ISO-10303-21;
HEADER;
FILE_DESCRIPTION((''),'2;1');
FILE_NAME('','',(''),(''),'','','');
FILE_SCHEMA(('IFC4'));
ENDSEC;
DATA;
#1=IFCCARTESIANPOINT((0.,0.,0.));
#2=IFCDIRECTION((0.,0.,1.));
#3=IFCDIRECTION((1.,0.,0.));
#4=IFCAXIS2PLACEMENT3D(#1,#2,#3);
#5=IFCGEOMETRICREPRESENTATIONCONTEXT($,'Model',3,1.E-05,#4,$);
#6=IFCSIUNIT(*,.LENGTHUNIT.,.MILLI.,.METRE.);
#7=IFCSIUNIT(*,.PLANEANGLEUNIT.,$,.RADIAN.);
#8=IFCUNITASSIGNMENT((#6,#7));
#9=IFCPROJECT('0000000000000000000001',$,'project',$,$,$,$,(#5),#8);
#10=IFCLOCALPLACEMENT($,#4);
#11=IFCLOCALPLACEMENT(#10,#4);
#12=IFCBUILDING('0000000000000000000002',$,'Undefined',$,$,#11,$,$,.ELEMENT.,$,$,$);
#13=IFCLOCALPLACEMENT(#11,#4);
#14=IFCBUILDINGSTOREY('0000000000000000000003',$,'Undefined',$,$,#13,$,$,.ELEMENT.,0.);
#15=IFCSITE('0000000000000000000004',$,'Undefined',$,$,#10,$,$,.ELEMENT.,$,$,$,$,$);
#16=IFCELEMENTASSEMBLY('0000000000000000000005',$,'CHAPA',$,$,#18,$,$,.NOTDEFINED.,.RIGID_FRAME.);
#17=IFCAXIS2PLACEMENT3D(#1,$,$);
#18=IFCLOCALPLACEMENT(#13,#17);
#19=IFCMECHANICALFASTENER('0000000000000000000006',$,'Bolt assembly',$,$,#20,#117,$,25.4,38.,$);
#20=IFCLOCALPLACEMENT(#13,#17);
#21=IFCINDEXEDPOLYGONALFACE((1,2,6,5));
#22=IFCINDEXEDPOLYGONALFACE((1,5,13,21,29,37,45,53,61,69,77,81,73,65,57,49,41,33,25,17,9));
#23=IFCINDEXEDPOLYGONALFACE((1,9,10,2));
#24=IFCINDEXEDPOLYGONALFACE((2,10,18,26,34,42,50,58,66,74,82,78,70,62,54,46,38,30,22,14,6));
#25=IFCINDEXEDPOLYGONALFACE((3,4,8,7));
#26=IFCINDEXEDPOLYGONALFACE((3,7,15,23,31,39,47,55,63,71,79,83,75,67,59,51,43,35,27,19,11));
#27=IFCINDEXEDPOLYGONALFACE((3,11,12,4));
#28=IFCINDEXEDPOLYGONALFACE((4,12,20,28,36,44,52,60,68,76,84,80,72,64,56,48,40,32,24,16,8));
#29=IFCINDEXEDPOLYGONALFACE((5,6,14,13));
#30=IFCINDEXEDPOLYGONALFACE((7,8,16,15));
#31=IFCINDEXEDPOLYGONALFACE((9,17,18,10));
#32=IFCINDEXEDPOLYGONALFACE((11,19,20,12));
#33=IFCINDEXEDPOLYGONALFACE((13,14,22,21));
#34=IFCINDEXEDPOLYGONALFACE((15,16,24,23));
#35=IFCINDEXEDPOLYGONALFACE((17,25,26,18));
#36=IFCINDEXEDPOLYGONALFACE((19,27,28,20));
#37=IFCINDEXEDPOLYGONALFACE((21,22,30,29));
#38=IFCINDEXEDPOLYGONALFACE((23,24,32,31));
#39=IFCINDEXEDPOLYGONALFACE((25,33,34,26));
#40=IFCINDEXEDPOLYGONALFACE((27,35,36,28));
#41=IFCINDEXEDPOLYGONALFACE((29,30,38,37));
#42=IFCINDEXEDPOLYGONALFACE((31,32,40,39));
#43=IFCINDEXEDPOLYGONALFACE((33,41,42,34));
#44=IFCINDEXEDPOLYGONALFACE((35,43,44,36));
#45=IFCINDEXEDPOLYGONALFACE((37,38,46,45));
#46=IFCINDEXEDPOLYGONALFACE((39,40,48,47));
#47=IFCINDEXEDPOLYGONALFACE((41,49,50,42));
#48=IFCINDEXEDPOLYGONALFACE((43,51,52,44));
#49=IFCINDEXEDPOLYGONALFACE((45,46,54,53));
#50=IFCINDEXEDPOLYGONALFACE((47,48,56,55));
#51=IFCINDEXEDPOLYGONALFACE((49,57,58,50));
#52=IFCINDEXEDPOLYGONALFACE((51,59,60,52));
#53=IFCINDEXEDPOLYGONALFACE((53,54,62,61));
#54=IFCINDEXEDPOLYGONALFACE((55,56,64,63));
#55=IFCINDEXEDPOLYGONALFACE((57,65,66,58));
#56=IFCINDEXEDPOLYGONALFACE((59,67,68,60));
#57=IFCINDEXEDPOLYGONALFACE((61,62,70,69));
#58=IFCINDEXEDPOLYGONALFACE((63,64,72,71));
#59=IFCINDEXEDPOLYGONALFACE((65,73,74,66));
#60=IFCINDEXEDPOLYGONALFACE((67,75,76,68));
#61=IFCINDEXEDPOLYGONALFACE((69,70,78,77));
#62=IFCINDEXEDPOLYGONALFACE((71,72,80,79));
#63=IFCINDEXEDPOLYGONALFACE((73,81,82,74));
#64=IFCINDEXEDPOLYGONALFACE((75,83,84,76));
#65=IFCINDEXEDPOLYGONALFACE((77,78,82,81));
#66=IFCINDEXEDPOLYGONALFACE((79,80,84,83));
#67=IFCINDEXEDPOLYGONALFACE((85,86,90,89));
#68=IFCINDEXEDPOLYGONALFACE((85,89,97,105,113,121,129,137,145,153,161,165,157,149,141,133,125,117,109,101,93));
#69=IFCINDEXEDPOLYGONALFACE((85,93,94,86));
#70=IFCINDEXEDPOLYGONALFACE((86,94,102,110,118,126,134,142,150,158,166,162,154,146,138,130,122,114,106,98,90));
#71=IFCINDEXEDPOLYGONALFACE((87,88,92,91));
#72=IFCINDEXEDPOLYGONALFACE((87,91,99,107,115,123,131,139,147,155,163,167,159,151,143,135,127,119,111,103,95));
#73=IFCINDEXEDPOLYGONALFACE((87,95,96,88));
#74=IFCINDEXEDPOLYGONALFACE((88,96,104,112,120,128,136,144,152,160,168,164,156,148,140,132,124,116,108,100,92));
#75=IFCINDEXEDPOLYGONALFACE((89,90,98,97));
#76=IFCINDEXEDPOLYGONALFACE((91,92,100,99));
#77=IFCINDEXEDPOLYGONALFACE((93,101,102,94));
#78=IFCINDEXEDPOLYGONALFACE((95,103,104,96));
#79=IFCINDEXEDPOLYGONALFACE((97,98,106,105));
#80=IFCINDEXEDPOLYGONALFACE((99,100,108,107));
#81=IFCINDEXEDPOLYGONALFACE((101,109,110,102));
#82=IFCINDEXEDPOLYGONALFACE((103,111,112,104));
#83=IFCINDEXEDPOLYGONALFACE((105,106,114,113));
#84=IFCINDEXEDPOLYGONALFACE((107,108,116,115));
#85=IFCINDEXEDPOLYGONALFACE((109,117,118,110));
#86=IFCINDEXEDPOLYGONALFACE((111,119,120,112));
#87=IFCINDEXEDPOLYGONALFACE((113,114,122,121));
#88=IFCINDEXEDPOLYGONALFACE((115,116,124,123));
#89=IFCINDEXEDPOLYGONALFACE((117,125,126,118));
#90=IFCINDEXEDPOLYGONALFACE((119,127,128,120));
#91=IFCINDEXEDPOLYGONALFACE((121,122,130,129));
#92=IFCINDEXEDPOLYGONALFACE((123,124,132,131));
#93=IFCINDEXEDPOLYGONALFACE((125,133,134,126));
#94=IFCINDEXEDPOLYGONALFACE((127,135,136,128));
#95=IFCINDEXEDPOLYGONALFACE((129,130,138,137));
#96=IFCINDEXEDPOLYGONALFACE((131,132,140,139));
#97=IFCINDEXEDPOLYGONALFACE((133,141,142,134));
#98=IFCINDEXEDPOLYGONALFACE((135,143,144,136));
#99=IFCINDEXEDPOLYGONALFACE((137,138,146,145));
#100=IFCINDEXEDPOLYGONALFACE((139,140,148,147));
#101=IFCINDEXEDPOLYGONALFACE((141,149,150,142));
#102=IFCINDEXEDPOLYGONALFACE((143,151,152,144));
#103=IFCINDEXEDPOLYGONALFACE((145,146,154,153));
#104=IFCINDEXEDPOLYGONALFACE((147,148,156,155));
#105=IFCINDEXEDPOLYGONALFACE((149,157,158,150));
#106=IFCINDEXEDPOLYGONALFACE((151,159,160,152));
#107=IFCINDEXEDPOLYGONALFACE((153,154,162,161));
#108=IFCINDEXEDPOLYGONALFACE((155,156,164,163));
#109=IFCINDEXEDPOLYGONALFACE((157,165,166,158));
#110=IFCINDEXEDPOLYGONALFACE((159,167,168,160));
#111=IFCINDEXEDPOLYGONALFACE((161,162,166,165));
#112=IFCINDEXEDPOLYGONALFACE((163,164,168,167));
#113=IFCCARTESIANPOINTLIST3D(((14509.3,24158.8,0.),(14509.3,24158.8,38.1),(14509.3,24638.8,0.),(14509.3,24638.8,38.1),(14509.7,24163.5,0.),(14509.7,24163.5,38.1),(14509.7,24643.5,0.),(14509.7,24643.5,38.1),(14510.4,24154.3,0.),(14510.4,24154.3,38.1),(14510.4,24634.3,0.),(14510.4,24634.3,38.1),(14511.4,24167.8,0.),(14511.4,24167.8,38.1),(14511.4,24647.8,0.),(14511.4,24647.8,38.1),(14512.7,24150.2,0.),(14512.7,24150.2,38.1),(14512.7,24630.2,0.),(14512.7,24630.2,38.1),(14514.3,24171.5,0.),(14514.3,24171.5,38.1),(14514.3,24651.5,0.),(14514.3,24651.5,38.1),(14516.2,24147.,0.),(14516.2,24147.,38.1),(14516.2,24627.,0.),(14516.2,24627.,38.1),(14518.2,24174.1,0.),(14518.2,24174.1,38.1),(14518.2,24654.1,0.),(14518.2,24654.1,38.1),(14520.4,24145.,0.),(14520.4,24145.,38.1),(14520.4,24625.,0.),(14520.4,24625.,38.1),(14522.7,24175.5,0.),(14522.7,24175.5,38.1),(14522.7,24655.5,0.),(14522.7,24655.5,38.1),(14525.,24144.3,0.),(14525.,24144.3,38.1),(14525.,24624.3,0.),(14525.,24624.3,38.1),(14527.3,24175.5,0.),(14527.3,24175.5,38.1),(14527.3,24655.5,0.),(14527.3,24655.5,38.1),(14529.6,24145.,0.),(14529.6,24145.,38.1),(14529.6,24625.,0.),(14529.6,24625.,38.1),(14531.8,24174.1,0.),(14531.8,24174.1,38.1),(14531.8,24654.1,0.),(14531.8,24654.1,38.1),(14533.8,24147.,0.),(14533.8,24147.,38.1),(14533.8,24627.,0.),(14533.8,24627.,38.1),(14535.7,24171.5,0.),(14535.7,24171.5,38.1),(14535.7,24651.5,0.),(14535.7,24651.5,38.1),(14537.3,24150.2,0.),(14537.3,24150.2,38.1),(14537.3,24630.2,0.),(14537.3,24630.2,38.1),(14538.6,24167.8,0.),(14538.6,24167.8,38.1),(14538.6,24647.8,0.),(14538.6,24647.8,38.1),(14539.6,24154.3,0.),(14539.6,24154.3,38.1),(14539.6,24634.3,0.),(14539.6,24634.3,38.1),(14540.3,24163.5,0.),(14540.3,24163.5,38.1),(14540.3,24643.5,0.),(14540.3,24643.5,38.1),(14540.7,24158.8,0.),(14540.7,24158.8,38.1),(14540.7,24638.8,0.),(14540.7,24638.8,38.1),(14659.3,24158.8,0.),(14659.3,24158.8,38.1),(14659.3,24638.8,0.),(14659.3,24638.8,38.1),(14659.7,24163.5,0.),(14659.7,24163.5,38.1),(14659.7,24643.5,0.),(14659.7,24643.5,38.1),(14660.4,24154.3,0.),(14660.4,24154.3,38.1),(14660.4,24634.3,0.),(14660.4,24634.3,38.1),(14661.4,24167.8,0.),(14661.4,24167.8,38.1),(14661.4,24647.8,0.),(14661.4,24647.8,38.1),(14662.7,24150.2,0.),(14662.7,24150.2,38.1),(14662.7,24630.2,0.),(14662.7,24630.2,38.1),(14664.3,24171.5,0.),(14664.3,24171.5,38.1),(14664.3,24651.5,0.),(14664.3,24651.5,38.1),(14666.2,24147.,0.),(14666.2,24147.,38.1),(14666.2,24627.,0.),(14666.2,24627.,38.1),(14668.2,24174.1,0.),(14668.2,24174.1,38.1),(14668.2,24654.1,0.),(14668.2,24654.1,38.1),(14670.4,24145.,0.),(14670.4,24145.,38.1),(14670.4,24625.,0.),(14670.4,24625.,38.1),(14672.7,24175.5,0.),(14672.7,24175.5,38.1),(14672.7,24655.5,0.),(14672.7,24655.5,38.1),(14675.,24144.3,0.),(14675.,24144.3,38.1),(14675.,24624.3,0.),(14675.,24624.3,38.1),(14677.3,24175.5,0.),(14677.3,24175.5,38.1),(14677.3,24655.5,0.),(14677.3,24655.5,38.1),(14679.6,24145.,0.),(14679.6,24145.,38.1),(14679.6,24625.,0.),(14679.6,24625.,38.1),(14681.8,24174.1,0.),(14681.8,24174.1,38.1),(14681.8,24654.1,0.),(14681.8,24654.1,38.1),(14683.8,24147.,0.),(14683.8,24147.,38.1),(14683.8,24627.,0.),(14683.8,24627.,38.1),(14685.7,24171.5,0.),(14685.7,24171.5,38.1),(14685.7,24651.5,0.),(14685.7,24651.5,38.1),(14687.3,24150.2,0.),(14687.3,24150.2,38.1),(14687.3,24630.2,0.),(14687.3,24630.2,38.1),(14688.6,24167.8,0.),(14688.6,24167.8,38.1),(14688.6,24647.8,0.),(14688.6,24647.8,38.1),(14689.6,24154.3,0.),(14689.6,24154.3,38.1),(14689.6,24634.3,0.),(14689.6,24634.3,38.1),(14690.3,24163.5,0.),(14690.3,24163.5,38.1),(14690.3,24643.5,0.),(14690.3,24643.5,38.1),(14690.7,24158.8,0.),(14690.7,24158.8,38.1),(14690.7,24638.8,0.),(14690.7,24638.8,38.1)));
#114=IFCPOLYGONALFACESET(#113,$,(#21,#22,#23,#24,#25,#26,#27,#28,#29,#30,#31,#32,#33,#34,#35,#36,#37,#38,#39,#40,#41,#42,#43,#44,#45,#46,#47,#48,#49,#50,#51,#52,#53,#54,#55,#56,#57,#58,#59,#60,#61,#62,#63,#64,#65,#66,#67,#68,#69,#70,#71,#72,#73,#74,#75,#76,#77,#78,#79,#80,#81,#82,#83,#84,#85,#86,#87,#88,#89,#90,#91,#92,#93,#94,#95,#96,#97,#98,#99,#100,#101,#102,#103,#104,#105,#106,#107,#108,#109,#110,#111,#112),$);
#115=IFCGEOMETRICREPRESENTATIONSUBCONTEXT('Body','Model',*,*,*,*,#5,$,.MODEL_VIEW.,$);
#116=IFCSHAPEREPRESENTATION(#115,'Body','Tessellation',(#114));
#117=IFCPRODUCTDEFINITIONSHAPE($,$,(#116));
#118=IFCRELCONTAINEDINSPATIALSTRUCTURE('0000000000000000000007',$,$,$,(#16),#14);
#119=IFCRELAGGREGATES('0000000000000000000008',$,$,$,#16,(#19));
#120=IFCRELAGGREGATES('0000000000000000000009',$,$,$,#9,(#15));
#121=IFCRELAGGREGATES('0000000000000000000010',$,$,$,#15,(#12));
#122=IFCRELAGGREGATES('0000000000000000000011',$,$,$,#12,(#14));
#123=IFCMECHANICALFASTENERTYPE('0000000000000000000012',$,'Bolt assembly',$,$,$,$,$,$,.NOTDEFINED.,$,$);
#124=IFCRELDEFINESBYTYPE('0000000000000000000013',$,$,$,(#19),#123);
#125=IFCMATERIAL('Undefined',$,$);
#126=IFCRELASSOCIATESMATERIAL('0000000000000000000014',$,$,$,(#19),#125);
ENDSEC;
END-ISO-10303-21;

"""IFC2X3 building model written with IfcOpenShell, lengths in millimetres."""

from ifc_helpers import new_model, si_unit, frame, origin_with_axes, origin_2d_with_axis, place, context, subcontext, project, spatial, circle, extrude, source, transform, mapped, material, type_object, element, aggregate, save


model = new_model("IFC2X3")

# Units and contexts
model_context = context("Model", 3, precision=1e-05, world=origin_with_axes())
body_context = subcontext(model_context, "Body", "Model", "MODEL_VIEW")
ifc_project = project(units=[si_unit("LENGTHUNIT", "METRE", prefix="MILLI"), si_unit("PLANEANGLEUNIT", "RADIAN")], contexts=[model_context])

# Site, building, storey
site_placement = place(None, origin_with_axes())
site = spatial("IfcSite", under=ifc_project, at=site_placement, Name="Undefined", CompositionType="ELEMENT")
building_placement = place(site_placement, origin_with_axes())
building = spatial("IfcBuilding", under=site, at=building_placement, Name="Undefined", CompositionType="ELEMENT")
storey_placement = place(building_placement, origin_with_axes())
storey = spatial("IfcBuildingStorey", under=building, at=storey_placement, Name="Undefined", CompositionType="ELEMENT", Elevation=0.0)

# Element assembly
assembly_1_placement = place(storey_placement, origin_with_axes())
assembly_1 = element("IfcElementAssembly", 1, at=assembly_1_placement, inside=storey, Name="CHAPA", AssemblyPlace="NOTDEFINED", PredefinedType="RIGID_FRAME")

# Shared definitions
ifc_material_1 = material(Name="Undefined")
mechanical_fastener_type = type_object("IfcMechanicalFastenerType", Name="Bolt assembly")

# Mechanical fastener
shared_shape_1 = source(origin_with_axes(), body_context, "Body", "SweptSolid", [
    extrude(circle(Radius=15.7, at=origin_2d_with_axis()), frame((0.0, -38.0, 0.0), z_axis=(0.0, 1.0, 0.0), x_axis=(1.0, 0.0, 0.0)), (0.0, 0.0, 1.0), 38.1),
])
mechanical_fastener_1_placement = place(assembly_1_placement, frame((14600.0, 24640.0, 38.0), z_axis=(-1.0, 0.0, 0.0), x_axis=(0.0, -1.0, 0.0)))
mechanical_fastener_1 = element("IfcMechanicalFastener", 2, at=mechanical_fastener_1_placement, type_object=mechanical_fastener_type, material=ifc_material_1, Name="Bolt assembly", NominalDiameter=25.4, NominalLength=38.0, context=body_context, shape_type="MappedRepresentation", body=[
    mapped(shared_shape_1, transform((0.0, 0.0, -75.0))),
    mapped(shared_shape_1, transform((0.0, 0.0, 75.0))),
    mapped(shared_shape_1, transform((480.0, 0.0, -75.0))),
    mapped(shared_shape_1, transform((480.0, 0.0, 75.0))),
])
aggregate(assembly_1, [mechanical_fastener_1])

save(model, "model.ifc")
